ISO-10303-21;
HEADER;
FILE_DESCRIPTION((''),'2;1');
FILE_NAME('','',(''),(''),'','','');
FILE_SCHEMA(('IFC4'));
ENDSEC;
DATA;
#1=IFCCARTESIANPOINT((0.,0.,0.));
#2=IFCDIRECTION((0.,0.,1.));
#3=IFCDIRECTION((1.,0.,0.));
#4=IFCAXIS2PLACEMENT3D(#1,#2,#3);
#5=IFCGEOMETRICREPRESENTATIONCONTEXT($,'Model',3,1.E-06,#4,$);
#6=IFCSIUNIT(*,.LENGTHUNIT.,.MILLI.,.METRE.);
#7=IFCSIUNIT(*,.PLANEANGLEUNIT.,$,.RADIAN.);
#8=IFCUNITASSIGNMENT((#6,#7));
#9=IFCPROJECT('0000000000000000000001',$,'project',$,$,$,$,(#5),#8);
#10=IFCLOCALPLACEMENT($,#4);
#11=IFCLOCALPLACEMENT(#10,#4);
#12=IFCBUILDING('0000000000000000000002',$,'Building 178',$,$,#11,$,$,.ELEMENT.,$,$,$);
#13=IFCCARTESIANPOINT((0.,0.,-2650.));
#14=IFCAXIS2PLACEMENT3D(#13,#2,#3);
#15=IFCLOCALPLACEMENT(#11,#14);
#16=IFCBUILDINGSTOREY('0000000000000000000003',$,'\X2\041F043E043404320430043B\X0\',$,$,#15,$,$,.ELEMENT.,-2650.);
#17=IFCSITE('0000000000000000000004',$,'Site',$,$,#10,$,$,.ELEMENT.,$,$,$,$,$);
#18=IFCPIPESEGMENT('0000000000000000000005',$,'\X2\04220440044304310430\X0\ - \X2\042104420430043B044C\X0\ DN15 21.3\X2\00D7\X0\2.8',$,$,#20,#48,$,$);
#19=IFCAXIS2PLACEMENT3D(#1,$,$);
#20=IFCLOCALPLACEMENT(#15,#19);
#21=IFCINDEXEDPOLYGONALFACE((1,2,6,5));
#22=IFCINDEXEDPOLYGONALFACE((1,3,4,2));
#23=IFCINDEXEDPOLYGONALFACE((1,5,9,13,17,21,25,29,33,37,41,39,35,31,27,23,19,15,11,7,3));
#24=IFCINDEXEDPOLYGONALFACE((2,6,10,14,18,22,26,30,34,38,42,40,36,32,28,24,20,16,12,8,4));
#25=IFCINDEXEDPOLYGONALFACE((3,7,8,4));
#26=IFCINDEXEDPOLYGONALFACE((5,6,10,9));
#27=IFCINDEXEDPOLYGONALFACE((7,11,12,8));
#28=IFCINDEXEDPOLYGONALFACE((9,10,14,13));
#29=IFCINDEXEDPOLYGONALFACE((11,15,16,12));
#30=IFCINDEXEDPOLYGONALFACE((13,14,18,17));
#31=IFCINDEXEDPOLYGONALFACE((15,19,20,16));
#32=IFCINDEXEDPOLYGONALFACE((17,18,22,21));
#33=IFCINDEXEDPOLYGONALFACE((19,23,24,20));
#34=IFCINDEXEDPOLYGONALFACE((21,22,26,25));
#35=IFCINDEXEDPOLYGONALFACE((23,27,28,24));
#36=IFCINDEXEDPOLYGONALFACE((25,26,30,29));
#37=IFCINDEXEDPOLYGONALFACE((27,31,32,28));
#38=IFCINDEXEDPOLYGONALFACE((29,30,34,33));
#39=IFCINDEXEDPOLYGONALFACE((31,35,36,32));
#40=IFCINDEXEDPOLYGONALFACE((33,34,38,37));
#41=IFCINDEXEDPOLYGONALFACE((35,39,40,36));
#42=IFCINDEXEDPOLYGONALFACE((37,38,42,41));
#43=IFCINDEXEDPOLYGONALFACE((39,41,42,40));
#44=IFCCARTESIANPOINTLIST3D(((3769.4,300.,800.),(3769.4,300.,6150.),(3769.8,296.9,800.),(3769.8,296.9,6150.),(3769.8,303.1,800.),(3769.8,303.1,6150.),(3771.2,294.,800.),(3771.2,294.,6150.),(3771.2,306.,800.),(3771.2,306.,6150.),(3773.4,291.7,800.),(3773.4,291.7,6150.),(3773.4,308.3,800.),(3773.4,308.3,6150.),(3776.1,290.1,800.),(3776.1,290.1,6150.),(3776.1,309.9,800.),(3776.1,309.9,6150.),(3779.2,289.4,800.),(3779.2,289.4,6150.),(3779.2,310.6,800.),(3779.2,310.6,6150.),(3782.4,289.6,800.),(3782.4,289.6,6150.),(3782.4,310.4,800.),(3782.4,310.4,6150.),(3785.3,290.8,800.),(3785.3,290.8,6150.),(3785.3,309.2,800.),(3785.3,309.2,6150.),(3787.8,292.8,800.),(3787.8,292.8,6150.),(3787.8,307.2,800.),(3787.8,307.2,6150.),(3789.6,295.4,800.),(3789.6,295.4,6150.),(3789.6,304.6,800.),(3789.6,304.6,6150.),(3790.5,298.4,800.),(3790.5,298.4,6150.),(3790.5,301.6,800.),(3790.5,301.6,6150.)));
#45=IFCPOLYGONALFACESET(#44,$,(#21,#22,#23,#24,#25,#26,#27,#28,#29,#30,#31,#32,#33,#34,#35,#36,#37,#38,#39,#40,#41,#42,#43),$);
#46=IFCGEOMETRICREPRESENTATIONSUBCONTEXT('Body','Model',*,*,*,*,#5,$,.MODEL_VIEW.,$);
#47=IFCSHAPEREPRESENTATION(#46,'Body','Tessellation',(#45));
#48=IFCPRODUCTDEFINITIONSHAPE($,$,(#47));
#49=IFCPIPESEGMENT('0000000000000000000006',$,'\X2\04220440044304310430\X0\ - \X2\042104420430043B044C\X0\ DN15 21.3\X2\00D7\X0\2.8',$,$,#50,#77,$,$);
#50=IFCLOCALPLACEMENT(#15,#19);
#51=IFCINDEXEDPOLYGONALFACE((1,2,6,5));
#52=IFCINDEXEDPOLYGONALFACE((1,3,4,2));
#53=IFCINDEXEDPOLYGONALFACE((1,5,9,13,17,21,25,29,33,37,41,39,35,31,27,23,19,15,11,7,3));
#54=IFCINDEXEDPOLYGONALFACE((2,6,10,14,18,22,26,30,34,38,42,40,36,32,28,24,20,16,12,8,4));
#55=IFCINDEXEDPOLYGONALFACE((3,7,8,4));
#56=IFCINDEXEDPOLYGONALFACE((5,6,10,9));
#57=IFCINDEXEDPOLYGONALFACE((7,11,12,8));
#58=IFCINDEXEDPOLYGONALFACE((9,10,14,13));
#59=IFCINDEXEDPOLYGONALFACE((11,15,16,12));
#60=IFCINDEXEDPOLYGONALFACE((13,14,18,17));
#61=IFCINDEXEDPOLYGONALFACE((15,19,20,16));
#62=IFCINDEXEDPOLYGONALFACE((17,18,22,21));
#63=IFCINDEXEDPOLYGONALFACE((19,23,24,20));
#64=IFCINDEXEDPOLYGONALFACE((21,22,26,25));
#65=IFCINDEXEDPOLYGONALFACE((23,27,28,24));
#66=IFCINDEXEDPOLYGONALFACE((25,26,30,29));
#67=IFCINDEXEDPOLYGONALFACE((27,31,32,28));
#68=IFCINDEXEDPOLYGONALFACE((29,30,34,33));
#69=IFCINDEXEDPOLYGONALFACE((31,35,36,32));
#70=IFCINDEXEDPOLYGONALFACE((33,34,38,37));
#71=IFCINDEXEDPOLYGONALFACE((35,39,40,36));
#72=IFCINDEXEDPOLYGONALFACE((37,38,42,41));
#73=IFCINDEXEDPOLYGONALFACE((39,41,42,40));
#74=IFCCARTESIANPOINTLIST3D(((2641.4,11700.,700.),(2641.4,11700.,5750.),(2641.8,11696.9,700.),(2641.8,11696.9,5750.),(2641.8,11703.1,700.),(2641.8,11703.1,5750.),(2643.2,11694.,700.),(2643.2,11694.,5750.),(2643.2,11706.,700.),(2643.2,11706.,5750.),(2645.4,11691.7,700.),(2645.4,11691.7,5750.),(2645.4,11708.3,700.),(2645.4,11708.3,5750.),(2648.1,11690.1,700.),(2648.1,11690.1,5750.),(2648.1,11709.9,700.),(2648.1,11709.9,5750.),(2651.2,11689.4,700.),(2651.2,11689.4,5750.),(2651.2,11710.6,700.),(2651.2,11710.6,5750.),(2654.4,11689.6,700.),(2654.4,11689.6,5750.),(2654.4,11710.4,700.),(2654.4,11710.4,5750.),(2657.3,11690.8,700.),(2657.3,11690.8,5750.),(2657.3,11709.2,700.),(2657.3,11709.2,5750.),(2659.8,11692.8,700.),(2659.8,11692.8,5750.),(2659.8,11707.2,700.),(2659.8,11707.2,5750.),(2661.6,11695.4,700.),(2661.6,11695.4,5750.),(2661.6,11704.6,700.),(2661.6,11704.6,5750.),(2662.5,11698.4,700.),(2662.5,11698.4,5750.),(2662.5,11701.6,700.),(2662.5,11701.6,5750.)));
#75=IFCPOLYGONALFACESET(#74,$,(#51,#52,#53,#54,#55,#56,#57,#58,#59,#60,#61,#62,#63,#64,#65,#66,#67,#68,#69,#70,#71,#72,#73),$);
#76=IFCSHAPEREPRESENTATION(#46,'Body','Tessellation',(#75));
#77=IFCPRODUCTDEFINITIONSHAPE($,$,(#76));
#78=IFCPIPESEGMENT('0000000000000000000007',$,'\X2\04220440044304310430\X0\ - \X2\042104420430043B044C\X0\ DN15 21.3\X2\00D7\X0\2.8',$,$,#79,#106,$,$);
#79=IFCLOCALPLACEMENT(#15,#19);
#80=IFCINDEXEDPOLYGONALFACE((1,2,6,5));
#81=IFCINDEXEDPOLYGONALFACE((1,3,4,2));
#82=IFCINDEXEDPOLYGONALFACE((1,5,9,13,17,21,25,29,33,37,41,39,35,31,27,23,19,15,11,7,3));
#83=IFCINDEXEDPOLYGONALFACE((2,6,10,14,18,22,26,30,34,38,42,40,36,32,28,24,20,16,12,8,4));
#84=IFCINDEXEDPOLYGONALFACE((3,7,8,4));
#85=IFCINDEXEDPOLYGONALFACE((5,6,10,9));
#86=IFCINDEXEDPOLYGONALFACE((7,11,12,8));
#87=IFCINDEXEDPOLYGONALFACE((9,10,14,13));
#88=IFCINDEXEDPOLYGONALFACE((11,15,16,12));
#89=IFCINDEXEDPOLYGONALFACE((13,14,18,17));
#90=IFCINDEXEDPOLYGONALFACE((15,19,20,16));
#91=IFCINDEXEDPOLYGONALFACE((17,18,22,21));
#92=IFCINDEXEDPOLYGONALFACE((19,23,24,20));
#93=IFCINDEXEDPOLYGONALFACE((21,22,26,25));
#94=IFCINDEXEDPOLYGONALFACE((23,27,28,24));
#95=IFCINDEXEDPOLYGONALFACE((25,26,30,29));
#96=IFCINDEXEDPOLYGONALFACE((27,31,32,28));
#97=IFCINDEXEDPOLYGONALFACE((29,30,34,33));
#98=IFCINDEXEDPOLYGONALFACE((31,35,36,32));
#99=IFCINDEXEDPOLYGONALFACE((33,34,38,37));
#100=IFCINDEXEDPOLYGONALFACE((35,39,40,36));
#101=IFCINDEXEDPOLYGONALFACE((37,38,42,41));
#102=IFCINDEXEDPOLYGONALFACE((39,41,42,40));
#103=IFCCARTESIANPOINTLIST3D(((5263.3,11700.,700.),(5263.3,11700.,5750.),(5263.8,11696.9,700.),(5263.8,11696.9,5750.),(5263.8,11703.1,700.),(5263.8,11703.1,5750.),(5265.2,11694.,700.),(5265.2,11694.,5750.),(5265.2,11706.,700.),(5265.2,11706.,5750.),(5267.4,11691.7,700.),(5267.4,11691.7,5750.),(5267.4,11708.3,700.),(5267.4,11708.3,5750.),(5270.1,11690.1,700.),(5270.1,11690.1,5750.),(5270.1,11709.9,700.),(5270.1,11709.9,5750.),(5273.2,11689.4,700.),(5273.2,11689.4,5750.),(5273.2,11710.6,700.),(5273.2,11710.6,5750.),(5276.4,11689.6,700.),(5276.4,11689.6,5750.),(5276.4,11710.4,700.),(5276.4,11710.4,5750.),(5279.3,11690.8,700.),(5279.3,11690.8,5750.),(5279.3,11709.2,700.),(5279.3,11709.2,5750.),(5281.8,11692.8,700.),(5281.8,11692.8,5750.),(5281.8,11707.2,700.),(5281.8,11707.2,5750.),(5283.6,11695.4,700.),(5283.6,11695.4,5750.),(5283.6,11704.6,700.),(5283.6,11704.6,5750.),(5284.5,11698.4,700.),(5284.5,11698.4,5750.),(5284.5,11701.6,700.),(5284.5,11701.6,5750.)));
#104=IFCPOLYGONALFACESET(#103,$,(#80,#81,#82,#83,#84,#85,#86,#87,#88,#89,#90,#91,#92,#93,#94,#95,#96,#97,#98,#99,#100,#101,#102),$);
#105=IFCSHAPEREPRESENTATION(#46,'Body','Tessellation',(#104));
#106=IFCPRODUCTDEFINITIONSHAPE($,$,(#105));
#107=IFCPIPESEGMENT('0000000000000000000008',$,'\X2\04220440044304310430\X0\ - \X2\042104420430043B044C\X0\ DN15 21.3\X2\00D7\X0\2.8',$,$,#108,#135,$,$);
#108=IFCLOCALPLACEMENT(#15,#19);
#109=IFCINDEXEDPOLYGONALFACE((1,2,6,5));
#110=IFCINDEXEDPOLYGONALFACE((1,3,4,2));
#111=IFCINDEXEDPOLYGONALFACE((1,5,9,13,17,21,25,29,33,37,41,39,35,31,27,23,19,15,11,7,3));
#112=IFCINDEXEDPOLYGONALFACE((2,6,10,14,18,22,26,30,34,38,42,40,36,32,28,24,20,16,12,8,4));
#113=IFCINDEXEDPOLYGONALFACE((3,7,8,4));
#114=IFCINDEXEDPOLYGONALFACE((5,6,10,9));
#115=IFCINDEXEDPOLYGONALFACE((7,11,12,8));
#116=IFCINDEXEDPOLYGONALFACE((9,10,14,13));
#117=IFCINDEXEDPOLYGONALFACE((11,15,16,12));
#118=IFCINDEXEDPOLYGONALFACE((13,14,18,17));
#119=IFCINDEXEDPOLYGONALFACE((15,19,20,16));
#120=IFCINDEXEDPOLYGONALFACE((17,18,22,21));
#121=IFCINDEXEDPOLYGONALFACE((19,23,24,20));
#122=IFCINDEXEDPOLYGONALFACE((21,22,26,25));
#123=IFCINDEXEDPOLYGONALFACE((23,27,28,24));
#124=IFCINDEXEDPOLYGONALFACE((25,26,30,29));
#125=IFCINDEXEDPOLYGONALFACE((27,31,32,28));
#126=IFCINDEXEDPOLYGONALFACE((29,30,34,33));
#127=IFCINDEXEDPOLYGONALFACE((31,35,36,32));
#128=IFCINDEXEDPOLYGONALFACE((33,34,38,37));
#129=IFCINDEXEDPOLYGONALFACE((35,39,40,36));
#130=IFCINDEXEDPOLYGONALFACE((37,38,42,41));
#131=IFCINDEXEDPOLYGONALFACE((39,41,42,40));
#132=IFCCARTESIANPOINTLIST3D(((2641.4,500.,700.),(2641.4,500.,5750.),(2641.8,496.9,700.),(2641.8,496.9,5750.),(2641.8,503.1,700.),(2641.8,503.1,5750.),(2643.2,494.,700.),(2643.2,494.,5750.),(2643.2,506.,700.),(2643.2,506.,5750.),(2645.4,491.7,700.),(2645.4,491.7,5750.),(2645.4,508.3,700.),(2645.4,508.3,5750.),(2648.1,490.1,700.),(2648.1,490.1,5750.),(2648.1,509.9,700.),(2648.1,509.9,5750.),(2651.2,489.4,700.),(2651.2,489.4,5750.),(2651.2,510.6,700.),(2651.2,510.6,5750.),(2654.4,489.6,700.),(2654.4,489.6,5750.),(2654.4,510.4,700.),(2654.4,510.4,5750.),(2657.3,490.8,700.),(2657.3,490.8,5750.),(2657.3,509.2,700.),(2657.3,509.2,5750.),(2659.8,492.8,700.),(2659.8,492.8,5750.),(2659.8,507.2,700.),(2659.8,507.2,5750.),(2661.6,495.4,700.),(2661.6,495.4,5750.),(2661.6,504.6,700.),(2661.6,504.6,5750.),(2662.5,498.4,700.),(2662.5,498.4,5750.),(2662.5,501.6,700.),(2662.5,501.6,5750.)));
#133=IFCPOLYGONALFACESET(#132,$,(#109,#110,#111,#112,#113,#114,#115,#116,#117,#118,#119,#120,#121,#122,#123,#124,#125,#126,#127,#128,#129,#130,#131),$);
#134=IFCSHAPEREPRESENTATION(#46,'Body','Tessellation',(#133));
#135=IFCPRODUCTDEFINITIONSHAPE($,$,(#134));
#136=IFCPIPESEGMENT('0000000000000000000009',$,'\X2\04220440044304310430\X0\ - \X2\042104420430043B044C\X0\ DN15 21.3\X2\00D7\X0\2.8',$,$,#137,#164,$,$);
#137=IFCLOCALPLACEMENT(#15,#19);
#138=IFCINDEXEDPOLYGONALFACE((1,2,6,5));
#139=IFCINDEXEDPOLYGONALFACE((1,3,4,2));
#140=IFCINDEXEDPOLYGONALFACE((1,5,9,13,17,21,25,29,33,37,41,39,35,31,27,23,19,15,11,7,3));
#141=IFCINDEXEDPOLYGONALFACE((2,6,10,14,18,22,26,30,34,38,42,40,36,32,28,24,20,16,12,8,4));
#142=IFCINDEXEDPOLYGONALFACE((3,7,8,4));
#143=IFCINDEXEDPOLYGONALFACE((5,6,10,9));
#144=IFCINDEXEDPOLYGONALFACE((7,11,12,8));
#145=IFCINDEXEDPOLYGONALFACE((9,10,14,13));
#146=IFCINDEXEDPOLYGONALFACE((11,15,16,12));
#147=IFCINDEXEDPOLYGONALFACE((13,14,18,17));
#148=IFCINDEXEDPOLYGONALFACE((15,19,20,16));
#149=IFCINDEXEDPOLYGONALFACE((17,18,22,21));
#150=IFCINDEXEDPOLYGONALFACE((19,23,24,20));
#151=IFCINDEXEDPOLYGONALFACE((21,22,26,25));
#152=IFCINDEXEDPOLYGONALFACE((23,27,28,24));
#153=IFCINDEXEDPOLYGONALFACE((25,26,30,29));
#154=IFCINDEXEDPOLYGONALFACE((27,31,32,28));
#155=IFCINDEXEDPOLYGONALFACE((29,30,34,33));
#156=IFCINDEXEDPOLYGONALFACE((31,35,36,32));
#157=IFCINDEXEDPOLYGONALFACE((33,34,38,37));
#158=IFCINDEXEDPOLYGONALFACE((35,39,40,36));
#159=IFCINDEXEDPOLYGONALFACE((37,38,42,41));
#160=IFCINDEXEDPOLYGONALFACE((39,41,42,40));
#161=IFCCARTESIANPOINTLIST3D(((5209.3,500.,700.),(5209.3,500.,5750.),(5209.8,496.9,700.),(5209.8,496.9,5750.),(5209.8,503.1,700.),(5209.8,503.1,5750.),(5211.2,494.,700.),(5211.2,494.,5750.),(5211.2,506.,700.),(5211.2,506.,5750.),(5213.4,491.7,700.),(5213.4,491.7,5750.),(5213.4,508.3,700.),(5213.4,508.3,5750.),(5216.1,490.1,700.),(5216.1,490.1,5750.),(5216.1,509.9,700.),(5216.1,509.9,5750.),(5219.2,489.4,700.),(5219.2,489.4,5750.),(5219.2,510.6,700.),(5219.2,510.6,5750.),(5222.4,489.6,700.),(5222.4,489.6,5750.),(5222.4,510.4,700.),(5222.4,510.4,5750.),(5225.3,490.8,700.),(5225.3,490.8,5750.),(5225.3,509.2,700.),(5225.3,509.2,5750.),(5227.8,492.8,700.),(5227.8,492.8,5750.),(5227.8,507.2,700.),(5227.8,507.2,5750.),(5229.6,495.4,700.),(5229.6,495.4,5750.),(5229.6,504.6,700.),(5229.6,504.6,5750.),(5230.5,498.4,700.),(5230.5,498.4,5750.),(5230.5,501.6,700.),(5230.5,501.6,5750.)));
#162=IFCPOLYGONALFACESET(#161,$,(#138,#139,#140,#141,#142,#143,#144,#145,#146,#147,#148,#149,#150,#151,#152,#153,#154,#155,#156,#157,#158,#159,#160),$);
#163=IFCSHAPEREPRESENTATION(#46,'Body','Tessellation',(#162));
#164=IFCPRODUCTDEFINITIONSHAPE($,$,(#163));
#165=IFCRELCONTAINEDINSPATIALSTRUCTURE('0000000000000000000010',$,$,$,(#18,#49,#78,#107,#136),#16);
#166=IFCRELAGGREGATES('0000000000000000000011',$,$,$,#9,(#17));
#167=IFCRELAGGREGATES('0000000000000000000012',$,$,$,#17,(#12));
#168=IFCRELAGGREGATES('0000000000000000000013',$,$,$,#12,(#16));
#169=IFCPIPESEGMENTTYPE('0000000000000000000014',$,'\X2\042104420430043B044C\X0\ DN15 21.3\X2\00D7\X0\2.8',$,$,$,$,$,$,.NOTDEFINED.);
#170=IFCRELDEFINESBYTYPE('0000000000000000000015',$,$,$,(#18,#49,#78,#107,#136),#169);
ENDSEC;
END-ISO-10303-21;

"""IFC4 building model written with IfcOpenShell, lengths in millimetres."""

from ifc_helpers import new_model, entity, si_unit, frame, origin_with_axes, place, context, subcontext, project, spatial, source, transform, mapped, type_object, element, save


model = new_model("IFC4")

# Units and contexts
model_context = context("Model", 3, precision=1e-06, world=origin_with_axes())
body_context = subcontext(model_context, "Body", "Model", "MODEL_VIEW")
ifc_project = project(units=[si_unit("LENGTHUNIT", "METRE", prefix="MILLI"), si_unit("PLANEANGLEUNIT", "RADIAN")], contexts=[model_context])

# Site, building, storey
site_placement = place(None, origin_with_axes())
site = spatial("IfcSite", under=ifc_project, at=site_placement, Name="Site", CompositionType="ELEMENT")
building_placement = place(site_placement, origin_with_axes())
building = spatial("IfcBuilding", under=site, at=building_placement, Name="Building 178", CompositionType="ELEMENT")
storey_placement = place(building_placement, frame((0.0, 0.0, -2650.0), z_axis=(0.0, 0.0, 1.0), x_axis=(1.0, 0.0, 0.0)))
storey = spatial("IfcBuildingStorey", under=building, at=storey_placement, Name="Подвал", CompositionType="ELEMENT", Elevation=-2650.0)

# Pipe segments
pipe_segment_type_1 = type_object("IfcPipeSegmentType", Name="Сталь DN15 21.3×2.8", PredefinedType="NOTDEFINED")
shared_shape_1 = source(origin_with_axes(), body_context, "Body", "AdvancedSweptSolid", [
    entity("IfcSweptDiskSolid", entity("IfcIndexedPolyCurve", entity("IfcCartesianPointList3D", [[0.0, 0.0, 0.0], [0.0, 0.0, -5350.0]]), [entity("IfcLineIndex", [1, 2])]), 10.7),
])
for number, where, z_axis, x_axis, name in (
    (1, (3780.0, 300.0, 6150.0), (0.0, 0.0, 1.0), (1.0, 0.0, 0.0), "Труба - Сталь DN15 21.3×2.8"),
):
    element("IfcPipeSegment", number, at=place(storey_placement, frame(where, z_axis=z_axis, x_axis=x_axis)), inside=storey, type_object=pipe_segment_type_1, Name=name, context=body_context, shape_type="MappedRepresentation", body=[
        mapped(shared_shape_1, transform((0.0, 0.0, 0.0), x_axis=(1.0, 0.0, 0.0), y_axis=(0.0, 1.0, 0.0), z_axis=(0.0, 0.0, 1.0), scale=1.0)),
    ])
shared_shape_2 = source(origin_with_axes(), body_context, "Body", "AdvancedSweptSolid", [
    entity("IfcSweptDiskSolid", entity("IfcIndexedPolyCurve", entity("IfcCartesianPointList3D", [[0.0, 0.0, 0.0], [0.0, 0.0, -5050.0]]), [entity("IfcLineIndex", [1, 2])]), 10.7),
])
for number, where, z_axis, x_axis, name in (
    (2, (2652.0, 11700.0, 5750.0), (0.0, 0.0, 1.0), (1.0, 0.0, 0.0), "Труба - Сталь DN15 21.3×2.8"),
    (3, (5274.0, 11700.0, 5750.0), (0.0, 0.0, 1.0), (1.0, 0.0, 0.0), "Труба - Сталь DN15 21.3×2.8"),
    (4, (2652.0, 500.0, 5750.0), (0.0, 0.0, 1.0), (1.0, 0.0, 0.0), "Труба - Сталь DN15 21.3×2.8"),
    (5, (5220.0, 500.0, 5750.0), (0.0, 0.0, 1.0), (1.0, 0.0, 0.0), "Труба - Сталь DN15 21.3×2.8"),
):
    element("IfcPipeSegment", number, at=place(storey_placement, frame(where, z_axis=z_axis, x_axis=x_axis)), inside=storey, type_object=pipe_segment_type_1, Name=name, context=body_context, shape_type="MappedRepresentation", body=[
        mapped(shared_shape_2, transform((0.0, 0.0, 0.0), x_axis=(1.0, 0.0, 0.0), y_axis=(0.0, 1.0, 0.0), z_axis=(0.0, 0.0, 1.0), scale=1.0)),
    ])

save(model, "model.ifc")
